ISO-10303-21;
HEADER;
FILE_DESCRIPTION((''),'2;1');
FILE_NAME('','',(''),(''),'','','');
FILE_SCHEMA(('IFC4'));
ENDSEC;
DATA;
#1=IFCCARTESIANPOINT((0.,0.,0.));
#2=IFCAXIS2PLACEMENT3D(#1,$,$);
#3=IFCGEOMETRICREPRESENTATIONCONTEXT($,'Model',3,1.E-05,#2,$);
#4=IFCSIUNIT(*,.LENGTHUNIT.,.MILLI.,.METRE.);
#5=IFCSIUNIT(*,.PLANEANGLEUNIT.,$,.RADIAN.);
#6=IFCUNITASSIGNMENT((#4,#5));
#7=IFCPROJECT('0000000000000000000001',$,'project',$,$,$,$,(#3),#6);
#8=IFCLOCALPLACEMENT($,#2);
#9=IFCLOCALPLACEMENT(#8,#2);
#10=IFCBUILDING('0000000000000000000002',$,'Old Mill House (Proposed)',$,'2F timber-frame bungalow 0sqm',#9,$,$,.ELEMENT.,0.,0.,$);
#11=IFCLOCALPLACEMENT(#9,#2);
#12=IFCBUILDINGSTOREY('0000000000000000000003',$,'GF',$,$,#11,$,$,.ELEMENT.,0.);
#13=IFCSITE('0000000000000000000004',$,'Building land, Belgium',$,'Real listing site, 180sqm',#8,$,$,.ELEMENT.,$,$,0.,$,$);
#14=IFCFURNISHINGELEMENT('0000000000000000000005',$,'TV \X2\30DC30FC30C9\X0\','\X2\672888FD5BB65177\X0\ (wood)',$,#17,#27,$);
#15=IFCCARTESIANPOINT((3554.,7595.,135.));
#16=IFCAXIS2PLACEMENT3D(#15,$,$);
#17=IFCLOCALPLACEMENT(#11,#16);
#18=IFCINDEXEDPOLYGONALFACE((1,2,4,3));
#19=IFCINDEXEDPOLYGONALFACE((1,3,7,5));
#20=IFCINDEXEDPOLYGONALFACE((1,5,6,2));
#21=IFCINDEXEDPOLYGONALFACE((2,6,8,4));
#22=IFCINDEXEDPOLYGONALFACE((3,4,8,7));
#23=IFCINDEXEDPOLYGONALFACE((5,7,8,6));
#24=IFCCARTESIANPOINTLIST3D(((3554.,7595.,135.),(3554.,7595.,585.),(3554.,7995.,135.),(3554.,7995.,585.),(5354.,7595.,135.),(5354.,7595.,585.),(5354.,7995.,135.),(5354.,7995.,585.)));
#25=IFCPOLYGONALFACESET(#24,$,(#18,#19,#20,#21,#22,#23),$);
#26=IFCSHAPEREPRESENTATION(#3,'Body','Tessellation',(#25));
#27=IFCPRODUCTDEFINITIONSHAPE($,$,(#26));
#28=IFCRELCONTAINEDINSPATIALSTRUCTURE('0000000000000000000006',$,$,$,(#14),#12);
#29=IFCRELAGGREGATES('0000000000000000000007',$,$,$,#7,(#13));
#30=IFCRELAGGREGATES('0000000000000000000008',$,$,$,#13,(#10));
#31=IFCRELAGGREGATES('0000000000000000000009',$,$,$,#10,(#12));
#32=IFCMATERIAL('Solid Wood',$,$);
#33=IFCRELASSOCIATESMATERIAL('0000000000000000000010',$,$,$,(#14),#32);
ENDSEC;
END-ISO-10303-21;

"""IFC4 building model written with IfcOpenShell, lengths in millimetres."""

from ifc_helpers import new_model, si_unit, frame, frame_2d, origin, place, context, project, spatial, rectangle, extrude, material, element, save


model = new_model("IFC4")

# Units and contexts
model_context = context("Model", 3, precision=1e-05, world=origin())
ifc_project = project(units=[si_unit("LENGTHUNIT", "METRE", prefix="MILLI"), si_unit("PLANEANGLEUNIT", "RADIAN")], contexts=[model_context])

# Site, building, storey
site_placement = place(None, origin())
site = spatial("IfcSite", under=ifc_project, at=site_placement, Name="Building land, Belgium", ObjectType="Real listing site, 180sqm", CompositionType="ELEMENT", RefElevation=0.0)
building_placement = place(site_placement, origin())
building = spatial("IfcBuilding", under=site, at=building_placement, Name="Old Mill House (Proposed)", ObjectType="2F timber-frame bungalow 0sqm", CompositionType="ELEMENT", ElevationOfRefHeight=0.0, ElevationOfTerrain=0.0)
storey_placement = place(building_placement, origin())
storey = spatial("IfcBuildingStorey", under=building, at=storey_placement, Name="GF", CompositionType="ELEMENT", Elevation=0.0)

# Shared definitions
ifc_material_1 = material(Name="Solid Wood")

# Furnishing element
furnishing_1_placement = place(storey_placement, frame((3554.0, 7595.0, 135.0)))
element("IfcFurnishingElement", 1, at=furnishing_1_placement, inside=storey, material=ifc_material_1, Name="TV ボード", Description="木製家具 (wood)", context=model_context, shape_type="SweptSolid", body=[
    extrude(rectangle(XDim=1800.0, YDim=400.0, at=frame_2d((900.0, 200.0))), frame((3554.0, 7595.0, 135.0)), (0.0, 0.0, 1.0), 450.0),
])

save(model, "model.ifc")
